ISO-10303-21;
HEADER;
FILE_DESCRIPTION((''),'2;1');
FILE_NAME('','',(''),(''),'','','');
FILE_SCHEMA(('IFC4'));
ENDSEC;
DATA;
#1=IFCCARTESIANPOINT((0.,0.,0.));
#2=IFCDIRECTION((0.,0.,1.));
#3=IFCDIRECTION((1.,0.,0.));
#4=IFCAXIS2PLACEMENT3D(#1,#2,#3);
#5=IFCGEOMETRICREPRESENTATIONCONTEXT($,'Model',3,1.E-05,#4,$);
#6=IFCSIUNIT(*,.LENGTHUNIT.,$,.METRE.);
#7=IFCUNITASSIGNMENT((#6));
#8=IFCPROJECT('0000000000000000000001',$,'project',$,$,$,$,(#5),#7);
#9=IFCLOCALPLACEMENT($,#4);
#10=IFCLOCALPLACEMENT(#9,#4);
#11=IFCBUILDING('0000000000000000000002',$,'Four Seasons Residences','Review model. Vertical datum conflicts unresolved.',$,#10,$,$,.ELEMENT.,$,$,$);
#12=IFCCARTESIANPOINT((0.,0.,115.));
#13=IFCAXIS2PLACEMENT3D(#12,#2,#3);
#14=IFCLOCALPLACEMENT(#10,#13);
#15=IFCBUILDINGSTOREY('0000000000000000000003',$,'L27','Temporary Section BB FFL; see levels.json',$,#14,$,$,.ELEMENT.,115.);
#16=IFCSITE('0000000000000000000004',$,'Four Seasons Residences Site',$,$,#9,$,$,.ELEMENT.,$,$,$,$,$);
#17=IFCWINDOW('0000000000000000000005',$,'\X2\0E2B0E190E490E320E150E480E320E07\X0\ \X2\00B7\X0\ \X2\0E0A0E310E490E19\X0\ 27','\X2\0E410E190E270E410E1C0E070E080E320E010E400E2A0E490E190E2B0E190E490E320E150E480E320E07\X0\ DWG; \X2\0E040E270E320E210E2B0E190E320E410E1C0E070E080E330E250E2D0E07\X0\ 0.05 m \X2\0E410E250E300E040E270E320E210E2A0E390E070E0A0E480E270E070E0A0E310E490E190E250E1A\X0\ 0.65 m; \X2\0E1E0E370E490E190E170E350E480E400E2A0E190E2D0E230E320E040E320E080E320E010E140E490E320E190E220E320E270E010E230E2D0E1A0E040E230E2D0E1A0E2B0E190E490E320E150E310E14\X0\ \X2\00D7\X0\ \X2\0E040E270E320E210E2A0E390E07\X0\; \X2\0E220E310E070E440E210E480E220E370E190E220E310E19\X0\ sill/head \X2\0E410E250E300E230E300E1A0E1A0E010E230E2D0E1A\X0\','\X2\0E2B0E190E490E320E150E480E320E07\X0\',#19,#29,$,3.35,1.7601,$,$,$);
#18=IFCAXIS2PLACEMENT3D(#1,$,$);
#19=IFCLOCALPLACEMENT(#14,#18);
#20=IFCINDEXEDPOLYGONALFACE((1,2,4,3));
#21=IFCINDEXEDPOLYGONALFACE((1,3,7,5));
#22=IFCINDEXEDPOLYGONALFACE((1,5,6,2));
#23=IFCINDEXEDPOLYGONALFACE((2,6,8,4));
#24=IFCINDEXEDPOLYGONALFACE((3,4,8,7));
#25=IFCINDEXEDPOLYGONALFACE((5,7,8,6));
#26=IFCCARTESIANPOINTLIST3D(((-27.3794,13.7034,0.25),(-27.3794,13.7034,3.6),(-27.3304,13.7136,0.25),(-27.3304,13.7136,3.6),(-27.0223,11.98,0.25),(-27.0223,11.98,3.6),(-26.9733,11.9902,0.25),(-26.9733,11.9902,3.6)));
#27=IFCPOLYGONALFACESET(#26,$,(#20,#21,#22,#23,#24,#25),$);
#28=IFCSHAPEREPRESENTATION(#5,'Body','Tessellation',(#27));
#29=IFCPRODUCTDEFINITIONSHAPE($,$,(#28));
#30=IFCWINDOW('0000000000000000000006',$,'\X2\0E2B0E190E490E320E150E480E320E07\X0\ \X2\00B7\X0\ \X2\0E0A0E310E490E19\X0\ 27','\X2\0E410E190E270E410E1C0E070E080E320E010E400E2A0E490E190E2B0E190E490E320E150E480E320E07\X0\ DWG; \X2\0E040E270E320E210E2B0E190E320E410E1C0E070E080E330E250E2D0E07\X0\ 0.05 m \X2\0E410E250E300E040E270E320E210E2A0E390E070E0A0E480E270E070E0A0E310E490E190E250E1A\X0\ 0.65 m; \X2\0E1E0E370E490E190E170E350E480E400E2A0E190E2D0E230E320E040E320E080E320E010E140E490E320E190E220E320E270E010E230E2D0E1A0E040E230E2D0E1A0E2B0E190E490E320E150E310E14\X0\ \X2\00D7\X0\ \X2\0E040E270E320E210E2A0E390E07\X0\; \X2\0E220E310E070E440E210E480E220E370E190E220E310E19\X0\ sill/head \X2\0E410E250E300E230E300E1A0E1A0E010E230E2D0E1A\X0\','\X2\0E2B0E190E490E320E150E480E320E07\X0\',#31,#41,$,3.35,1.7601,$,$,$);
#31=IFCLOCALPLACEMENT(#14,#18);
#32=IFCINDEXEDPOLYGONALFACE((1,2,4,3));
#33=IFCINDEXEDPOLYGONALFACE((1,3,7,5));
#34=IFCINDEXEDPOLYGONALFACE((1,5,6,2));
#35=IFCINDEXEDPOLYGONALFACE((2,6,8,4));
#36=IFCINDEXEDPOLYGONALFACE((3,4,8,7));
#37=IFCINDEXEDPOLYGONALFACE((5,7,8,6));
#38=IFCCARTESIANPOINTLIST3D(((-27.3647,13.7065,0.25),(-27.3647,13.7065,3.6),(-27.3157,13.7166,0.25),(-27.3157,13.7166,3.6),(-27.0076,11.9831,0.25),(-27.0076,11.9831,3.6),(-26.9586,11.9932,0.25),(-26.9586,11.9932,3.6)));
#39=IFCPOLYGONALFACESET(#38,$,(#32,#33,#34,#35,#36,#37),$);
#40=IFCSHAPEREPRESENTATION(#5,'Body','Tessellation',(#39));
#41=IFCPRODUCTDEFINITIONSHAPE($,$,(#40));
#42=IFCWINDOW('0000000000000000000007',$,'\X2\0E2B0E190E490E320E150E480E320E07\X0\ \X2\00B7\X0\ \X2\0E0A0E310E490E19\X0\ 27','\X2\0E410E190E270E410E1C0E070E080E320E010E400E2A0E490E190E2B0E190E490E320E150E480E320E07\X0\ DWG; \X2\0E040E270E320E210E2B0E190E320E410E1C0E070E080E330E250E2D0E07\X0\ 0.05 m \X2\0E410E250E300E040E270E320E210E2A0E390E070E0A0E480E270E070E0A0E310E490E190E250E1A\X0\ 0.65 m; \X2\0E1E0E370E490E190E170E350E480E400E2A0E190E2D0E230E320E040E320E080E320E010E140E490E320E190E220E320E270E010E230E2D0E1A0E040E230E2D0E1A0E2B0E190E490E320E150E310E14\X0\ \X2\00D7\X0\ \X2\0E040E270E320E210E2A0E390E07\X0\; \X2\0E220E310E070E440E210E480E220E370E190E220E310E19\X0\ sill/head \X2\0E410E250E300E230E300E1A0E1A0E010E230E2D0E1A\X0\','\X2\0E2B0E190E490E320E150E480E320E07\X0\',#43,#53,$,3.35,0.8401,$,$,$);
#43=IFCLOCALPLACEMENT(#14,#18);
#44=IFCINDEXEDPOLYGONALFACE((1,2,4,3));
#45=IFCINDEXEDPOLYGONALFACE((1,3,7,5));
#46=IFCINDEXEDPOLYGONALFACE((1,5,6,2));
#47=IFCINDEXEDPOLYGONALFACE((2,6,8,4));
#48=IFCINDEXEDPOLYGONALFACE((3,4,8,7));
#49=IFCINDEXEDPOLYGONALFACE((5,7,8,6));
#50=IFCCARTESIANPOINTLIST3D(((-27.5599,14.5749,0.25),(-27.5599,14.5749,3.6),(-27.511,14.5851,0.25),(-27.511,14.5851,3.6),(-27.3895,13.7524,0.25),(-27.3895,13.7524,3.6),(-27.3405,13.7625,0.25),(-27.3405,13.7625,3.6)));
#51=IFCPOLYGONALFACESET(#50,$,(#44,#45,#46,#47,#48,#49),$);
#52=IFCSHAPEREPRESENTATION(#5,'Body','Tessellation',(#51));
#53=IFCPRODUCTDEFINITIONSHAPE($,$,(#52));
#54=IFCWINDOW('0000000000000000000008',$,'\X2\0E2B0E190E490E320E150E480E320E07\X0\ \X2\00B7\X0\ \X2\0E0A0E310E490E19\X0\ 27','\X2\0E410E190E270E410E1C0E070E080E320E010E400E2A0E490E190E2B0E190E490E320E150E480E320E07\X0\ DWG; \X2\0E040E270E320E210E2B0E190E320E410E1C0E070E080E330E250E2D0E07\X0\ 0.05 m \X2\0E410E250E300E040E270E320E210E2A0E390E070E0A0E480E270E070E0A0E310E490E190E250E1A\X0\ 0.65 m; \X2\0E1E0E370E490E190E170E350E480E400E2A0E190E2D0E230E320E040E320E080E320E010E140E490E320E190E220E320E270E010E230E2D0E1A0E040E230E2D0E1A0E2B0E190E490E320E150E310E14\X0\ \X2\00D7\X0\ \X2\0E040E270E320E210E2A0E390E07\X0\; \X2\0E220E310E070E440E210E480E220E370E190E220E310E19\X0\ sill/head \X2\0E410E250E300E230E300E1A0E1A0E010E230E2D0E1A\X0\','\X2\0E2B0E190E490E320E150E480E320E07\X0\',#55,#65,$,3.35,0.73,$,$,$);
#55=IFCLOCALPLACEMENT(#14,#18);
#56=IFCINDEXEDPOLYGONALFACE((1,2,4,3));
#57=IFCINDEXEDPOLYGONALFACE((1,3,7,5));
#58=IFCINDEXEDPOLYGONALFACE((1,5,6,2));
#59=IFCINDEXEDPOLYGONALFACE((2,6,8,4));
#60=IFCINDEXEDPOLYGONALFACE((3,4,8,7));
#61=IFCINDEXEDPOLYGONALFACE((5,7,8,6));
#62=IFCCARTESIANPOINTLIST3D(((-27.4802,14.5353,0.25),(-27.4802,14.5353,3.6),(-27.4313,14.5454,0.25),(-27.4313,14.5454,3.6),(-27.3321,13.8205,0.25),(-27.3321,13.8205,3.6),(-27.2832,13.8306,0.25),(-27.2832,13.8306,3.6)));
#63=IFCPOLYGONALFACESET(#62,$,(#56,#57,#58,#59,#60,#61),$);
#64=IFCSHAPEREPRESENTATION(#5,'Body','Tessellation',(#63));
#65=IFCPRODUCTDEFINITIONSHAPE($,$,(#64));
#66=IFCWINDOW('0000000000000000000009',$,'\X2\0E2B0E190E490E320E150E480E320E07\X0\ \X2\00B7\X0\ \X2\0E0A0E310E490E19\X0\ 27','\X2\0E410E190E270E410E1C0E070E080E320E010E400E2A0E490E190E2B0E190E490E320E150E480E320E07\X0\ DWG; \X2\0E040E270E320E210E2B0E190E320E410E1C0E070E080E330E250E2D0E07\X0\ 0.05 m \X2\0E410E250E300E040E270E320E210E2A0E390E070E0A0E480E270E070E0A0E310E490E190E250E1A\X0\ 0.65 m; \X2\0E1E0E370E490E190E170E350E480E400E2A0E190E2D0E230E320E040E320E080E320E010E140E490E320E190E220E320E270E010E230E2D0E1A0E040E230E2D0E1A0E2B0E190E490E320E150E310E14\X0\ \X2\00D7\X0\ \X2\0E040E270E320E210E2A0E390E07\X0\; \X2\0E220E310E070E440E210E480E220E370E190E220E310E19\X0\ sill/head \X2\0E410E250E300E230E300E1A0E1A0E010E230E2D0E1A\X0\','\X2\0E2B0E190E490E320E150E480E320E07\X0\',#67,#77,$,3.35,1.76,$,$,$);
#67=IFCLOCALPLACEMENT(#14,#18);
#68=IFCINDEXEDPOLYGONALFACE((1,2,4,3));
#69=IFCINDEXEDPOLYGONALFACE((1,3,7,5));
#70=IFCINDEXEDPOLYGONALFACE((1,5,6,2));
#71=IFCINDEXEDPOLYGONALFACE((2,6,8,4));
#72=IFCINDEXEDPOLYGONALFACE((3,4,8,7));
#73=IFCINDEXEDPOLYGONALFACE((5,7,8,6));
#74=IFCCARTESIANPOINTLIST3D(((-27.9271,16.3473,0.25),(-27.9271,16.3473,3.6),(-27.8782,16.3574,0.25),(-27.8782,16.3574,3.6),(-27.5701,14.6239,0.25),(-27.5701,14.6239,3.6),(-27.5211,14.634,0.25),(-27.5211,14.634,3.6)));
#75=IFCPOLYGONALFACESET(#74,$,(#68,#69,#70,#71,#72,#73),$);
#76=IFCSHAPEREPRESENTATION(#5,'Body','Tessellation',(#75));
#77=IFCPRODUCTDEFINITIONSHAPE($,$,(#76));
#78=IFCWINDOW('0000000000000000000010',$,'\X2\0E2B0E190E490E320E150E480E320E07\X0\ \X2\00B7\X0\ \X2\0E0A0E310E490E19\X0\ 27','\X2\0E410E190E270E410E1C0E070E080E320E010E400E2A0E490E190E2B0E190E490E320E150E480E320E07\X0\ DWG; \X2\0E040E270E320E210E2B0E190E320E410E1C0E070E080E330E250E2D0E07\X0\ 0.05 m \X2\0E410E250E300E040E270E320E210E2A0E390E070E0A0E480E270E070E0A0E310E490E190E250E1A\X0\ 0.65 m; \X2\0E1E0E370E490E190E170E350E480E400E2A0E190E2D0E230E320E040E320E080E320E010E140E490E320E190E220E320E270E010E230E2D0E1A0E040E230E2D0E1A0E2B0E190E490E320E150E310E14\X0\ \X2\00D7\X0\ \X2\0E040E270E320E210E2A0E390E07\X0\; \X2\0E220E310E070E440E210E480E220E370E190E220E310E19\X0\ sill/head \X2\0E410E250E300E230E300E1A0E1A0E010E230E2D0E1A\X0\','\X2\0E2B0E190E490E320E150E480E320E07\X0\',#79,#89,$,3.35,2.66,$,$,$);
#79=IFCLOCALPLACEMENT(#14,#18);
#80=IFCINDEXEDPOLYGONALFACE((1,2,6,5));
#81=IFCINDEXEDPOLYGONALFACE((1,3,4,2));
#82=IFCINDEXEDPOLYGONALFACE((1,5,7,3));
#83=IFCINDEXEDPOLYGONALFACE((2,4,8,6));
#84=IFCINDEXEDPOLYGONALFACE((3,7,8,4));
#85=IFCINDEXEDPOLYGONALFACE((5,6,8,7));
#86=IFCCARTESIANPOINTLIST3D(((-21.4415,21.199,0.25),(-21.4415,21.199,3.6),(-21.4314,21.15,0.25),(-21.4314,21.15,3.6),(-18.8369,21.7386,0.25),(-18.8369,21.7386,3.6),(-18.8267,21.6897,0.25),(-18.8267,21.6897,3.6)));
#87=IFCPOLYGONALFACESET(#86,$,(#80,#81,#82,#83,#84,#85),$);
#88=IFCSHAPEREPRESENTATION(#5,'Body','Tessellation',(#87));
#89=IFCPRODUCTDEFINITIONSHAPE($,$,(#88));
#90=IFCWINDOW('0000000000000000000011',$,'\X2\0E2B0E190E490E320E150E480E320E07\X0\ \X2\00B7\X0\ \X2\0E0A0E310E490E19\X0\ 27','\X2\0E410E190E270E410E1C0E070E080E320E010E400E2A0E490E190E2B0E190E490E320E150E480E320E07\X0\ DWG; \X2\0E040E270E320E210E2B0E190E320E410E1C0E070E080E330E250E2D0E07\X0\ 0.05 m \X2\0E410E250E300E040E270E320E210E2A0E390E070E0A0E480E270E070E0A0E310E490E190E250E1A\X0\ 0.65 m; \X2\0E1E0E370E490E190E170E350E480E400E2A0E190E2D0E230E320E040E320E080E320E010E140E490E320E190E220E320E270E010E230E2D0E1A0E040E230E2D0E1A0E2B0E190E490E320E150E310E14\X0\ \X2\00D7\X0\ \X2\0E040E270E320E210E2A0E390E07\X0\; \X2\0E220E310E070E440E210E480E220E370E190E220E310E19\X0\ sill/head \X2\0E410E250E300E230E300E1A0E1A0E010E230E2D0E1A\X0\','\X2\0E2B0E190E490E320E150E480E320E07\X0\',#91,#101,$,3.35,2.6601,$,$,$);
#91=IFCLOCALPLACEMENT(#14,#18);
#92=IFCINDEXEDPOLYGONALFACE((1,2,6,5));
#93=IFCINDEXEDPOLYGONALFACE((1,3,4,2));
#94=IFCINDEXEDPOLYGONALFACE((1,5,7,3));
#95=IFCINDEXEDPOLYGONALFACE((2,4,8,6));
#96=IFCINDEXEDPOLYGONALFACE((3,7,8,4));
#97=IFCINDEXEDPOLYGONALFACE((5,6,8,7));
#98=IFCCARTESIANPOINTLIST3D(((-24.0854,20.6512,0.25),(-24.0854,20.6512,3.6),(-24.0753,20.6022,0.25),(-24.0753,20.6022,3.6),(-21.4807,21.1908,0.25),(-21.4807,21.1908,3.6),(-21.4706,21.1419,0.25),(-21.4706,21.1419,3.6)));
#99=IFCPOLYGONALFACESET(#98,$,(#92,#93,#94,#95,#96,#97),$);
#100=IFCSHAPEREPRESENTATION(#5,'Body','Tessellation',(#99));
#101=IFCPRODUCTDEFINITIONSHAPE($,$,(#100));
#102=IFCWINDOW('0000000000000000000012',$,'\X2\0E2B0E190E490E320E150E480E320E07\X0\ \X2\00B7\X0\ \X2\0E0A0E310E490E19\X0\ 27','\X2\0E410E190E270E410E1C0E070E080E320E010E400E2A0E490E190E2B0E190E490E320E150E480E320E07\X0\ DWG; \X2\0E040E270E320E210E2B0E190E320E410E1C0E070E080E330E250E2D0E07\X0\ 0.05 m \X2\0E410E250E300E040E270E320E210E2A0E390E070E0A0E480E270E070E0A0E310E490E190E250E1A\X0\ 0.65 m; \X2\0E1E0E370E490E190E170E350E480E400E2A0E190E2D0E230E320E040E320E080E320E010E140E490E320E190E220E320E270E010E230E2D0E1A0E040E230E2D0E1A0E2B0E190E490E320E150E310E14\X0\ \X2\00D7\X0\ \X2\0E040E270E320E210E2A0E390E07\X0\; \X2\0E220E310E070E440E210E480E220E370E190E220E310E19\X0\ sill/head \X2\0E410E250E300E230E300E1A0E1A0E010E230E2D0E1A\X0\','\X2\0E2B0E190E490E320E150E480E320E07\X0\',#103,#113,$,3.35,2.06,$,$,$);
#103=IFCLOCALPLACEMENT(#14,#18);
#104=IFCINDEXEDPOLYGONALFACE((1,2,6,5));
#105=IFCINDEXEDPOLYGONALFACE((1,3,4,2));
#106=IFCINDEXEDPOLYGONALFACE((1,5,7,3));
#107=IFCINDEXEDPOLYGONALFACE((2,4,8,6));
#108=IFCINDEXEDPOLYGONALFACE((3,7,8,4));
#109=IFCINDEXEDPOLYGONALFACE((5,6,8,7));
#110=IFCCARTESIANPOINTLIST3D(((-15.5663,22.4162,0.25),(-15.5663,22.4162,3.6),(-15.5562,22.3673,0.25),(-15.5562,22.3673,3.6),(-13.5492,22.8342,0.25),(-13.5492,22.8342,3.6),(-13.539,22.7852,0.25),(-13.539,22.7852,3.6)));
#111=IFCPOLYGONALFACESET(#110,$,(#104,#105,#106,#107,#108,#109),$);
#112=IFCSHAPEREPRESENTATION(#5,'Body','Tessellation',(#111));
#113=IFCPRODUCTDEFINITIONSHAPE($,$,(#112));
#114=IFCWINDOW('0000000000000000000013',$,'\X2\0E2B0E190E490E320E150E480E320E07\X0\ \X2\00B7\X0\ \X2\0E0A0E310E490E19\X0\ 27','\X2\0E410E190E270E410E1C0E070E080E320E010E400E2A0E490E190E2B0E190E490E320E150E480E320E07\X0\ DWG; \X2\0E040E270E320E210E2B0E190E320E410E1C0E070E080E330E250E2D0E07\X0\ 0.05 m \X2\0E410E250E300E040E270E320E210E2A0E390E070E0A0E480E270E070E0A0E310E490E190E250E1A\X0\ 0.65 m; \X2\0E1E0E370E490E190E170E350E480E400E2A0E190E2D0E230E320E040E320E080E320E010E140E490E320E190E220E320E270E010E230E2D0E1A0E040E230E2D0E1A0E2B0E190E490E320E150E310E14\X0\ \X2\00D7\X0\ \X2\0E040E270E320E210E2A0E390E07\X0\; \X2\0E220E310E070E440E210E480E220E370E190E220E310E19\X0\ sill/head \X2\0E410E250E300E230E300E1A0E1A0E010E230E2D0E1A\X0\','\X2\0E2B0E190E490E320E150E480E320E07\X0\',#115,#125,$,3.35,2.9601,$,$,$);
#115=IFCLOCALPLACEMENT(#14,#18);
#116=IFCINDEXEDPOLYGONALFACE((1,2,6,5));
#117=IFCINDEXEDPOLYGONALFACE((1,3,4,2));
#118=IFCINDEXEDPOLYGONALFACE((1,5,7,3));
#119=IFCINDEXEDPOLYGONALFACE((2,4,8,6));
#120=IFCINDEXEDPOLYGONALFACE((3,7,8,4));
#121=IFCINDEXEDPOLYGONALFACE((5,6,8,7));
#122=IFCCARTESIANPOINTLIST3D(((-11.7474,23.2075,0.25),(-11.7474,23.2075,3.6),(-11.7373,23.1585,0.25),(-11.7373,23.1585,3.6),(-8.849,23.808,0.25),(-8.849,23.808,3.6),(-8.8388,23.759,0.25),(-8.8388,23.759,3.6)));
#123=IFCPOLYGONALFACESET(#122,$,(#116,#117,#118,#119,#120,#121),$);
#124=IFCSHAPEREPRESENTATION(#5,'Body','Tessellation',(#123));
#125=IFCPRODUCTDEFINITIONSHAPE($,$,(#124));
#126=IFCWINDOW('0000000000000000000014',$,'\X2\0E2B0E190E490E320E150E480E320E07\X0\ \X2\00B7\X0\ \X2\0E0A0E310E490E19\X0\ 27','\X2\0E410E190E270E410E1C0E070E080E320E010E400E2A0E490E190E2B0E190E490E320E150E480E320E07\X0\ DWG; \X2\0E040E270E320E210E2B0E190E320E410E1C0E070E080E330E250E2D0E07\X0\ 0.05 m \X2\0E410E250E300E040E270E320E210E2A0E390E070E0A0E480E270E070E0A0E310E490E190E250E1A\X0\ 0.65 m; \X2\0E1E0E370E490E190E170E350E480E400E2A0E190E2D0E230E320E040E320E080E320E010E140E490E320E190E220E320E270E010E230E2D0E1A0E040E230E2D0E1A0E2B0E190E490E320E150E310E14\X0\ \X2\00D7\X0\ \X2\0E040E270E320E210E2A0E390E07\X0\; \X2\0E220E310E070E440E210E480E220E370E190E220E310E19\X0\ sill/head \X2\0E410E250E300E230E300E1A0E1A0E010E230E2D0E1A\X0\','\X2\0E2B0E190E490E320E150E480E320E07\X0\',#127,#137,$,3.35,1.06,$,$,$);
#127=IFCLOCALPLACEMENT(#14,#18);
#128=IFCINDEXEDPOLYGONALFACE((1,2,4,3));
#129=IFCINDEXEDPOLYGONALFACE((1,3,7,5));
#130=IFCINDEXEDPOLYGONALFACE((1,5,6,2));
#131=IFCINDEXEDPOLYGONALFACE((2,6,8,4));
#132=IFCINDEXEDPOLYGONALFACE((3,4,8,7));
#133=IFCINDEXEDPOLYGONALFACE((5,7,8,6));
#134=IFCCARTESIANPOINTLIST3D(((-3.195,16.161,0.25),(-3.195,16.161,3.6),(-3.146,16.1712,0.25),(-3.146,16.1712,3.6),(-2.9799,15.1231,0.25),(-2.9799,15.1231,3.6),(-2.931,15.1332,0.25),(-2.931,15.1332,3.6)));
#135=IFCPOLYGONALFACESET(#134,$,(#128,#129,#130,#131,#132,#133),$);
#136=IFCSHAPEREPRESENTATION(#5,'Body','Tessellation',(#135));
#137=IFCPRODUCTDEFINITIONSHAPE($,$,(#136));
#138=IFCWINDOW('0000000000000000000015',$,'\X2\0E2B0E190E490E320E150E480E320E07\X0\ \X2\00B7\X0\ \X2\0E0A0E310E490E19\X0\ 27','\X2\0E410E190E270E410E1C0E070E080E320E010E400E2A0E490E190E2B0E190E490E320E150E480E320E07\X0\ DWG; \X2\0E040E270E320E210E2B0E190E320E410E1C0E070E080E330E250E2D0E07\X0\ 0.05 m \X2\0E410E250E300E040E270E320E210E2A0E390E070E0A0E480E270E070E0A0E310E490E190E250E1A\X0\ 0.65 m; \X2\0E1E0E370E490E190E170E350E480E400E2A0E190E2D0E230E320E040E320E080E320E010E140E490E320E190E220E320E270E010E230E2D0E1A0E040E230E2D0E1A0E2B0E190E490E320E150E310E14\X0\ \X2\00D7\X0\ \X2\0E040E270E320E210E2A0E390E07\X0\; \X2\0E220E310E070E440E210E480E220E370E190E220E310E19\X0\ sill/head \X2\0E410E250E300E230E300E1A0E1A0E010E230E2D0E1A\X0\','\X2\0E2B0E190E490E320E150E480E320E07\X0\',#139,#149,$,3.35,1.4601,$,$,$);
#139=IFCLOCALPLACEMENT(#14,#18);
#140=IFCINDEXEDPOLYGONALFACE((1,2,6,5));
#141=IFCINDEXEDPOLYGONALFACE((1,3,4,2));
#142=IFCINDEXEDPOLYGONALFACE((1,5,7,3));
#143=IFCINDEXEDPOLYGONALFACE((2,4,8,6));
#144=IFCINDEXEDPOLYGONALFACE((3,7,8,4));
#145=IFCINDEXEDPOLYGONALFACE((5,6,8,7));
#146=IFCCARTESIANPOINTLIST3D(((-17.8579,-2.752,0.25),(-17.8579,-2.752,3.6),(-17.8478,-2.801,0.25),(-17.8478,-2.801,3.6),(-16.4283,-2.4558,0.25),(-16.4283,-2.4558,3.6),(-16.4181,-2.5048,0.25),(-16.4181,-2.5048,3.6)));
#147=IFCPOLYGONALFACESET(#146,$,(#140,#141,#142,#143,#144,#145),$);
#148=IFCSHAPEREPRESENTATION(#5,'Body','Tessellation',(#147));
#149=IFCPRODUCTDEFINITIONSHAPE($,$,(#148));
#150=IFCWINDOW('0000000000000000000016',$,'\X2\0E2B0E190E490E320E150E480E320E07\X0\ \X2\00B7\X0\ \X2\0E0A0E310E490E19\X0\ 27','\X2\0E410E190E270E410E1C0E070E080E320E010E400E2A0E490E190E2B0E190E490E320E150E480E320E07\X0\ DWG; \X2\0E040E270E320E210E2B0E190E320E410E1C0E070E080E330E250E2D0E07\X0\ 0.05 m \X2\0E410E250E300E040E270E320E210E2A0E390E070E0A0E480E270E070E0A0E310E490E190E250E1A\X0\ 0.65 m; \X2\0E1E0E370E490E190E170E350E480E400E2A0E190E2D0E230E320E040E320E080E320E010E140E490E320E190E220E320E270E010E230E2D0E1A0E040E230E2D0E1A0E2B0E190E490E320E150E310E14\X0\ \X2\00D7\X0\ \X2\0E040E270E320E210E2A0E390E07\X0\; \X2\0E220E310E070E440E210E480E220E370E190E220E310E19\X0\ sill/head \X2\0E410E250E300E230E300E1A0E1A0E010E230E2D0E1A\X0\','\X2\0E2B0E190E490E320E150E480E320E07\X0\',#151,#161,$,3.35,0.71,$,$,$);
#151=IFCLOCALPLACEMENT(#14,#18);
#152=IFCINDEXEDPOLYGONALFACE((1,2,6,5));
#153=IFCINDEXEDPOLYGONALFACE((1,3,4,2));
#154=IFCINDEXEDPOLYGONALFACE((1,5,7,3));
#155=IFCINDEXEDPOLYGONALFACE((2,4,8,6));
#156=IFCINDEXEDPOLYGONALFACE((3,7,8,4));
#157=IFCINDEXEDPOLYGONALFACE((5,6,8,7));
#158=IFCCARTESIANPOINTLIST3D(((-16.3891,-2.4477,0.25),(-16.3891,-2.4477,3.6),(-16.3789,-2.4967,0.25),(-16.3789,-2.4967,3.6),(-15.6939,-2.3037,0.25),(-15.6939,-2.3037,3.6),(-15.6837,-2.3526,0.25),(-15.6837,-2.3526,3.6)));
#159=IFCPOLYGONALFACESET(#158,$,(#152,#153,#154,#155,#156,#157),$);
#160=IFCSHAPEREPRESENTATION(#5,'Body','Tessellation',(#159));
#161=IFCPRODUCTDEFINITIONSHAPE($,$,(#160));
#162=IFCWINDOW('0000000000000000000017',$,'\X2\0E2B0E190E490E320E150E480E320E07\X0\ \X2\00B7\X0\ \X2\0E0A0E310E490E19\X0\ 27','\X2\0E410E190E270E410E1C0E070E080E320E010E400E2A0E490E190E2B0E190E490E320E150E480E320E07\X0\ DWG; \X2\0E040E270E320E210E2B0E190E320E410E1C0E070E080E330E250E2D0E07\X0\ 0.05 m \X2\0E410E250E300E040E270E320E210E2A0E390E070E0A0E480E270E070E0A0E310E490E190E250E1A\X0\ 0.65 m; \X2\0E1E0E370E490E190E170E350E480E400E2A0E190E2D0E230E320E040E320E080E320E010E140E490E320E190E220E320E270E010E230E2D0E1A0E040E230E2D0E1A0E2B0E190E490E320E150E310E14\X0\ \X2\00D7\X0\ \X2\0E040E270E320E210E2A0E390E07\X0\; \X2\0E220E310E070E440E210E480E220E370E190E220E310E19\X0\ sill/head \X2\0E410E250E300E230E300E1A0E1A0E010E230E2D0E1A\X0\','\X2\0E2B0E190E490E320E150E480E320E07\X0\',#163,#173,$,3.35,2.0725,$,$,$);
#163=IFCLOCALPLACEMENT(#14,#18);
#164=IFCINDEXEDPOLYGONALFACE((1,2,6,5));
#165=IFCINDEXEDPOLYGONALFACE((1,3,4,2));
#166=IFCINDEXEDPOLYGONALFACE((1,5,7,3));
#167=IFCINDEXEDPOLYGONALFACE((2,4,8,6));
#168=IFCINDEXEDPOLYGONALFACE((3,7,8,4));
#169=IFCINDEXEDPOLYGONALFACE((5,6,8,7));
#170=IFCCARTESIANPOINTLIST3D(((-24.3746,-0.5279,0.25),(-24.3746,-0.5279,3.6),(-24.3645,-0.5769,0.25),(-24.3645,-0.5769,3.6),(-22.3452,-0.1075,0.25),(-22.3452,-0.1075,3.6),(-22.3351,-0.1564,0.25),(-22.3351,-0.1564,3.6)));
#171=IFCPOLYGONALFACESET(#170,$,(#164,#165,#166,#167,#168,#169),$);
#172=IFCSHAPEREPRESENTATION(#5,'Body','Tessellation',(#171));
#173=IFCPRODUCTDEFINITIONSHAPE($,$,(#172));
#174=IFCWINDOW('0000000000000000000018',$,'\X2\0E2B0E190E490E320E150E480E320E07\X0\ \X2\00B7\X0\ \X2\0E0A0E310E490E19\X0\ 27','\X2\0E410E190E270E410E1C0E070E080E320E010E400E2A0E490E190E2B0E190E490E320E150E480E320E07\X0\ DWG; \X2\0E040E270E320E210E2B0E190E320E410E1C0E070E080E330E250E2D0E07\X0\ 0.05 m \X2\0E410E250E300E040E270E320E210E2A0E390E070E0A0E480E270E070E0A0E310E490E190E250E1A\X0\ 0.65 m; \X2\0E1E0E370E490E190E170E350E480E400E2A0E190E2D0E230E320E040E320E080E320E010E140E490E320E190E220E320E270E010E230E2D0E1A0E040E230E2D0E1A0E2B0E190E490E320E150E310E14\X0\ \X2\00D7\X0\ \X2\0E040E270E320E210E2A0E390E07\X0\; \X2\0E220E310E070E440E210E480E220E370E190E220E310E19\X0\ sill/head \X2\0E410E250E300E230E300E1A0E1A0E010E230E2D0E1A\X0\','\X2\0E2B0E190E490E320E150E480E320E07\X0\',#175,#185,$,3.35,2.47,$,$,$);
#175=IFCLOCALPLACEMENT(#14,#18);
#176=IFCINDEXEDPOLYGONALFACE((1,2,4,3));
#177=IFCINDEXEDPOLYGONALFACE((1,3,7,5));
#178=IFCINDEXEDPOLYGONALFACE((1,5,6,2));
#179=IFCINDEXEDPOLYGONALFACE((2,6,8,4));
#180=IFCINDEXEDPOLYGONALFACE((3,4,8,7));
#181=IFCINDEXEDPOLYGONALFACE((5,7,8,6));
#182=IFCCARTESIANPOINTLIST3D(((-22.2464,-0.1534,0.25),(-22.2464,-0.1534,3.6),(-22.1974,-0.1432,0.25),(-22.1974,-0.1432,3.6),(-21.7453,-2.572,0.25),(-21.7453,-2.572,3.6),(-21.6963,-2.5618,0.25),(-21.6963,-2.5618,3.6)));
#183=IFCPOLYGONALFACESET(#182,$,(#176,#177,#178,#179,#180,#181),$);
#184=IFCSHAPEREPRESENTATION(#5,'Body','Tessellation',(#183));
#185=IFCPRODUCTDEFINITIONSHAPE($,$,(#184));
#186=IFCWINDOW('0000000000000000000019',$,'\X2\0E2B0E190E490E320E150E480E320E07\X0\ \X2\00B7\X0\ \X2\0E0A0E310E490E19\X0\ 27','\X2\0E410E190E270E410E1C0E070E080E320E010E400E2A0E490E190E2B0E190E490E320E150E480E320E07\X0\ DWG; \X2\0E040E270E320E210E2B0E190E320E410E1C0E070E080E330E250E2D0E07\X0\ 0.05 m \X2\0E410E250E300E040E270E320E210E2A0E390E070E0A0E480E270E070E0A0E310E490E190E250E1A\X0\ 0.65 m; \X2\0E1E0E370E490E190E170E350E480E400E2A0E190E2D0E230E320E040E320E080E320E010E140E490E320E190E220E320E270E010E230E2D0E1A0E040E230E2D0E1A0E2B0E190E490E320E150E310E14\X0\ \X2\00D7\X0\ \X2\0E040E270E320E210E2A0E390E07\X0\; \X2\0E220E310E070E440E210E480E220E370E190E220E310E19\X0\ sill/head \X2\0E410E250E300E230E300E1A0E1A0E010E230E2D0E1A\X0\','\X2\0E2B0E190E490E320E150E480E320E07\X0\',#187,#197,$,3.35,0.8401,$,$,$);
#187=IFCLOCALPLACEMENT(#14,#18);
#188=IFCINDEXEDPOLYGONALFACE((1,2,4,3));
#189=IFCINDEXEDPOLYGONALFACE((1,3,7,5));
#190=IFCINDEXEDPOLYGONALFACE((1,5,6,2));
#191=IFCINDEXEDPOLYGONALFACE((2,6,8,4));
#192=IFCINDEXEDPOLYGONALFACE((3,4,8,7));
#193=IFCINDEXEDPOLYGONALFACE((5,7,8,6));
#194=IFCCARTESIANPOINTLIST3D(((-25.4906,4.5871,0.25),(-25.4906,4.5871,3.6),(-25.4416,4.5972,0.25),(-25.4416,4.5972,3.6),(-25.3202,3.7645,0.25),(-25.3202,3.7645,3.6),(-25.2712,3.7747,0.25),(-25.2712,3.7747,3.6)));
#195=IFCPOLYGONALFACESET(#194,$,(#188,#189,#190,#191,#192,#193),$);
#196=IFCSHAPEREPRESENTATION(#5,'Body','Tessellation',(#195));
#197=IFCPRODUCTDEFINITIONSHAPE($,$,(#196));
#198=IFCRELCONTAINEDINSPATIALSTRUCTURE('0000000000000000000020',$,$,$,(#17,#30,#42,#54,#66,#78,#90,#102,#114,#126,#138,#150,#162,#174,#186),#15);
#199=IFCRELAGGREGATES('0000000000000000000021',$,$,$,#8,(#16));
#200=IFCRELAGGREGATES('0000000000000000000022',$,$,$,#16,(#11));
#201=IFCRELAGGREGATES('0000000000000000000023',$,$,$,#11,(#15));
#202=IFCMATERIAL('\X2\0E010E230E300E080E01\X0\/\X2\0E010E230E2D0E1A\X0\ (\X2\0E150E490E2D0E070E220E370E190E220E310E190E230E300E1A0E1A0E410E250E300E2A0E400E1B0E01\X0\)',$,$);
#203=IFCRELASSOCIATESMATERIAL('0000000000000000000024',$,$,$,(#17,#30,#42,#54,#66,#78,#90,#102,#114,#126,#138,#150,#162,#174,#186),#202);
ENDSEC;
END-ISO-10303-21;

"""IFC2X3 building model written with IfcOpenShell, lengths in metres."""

from ifc_helpers import new_model, si_unit, frame, origin_with_axes, place, context, project, spatial, polyline, outline, extrude, material, element, save


model = new_model("IFC2X3")

# Units and contexts
model_context = context("Model", 3, precision=1e-05, world=origin_with_axes())
ifc_project = project(units=[si_unit("LENGTHUNIT", "METRE")], contexts=[model_context])

# Site, building, storey
site_placement = place(None, origin_with_axes())
site = spatial("IfcSite", under=ifc_project, at=site_placement, Name="Four Seasons Residences Site", CompositionType="ELEMENT")
building_placement = place(site_placement, origin_with_axes())
building = spatial("IfcBuilding", under=site, at=building_placement, Name="Four Seasons Residences", Description="Review model. Vertical datum conflicts unresolved.", CompositionType="ELEMENT")
storey_placement = place(building_placement, frame((0.0, 0.0, 115.0), z_axis=(0.0, 0.0, 1.0), x_axis=(1.0, 0.0, 0.0)))
storey = spatial("IfcBuildingStorey", under=building, at=storey_placement, Name="L27", Description="Temporary Section BB FFL; see levels.json", CompositionType="ELEMENT", Elevation=115.0)

# Windows
ifc_material = material(Name="กระจก/กรอบ (ต้องยืนยันระบบและสเปก)")
window_1_placement = place(storey_placement, origin_with_axes())
element("IfcWindow", 1, at=window_1_placement, inside=storey, material=ifc_material, Name="หน้าต่าง · ชั้น 27", Description="แนวแผงจากเส้นหน้าต่าง DWG; ความหนาแผงจำลอง 0.05 m และความสูงช่วงชั้นลบ 0.65 m; พื้นที่เสนอราคาจากด้านยาวกรอบครอบหน้าตัด × ความสูง; ยังไม่ยืนยัน sill/head และระบบกรอบ", ObjectType="หน้าต่าง", OverallHeight=3.35, OverallWidth=1.7601, context=model_context, shape_type="SweptSolid", body=[
    extrude(outline(polyline([(-26.9733, 11.9902), (-27.0223, 11.98), (-27.3794, 13.7034), (-27.3304, 13.7136), (-26.9733, 11.9902)])), frame((0.0, 0.0, 0.25), z_axis=(0.0, 0.0, 1.0), x_axis=(1.0, 0.0, 0.0)), (0.0, 0.0, 1.0), 3.35),
])
window_2_placement = place(storey_placement, origin_with_axes())
element("IfcWindow", 2, at=window_2_placement, inside=storey, material=ifc_material, Name="หน้าต่าง · ชั้น 27", Description="แนวแผงจากเส้นหน้าต่าง DWG; ความหนาแผงจำลอง 0.05 m และความสูงช่วงชั้นลบ 0.65 m; พื้นที่เสนอราคาจากด้านยาวกรอบครอบหน้าตัด × ความสูง; ยังไม่ยืนยัน sill/head และระบบกรอบ", ObjectType="หน้าต่าง", OverallHeight=3.35, OverallWidth=1.7601, context=model_context, shape_type="SweptSolid", body=[
    extrude(outline(polyline([(-26.9586, 11.9932), (-27.0076, 11.9831), (-27.3647, 13.7065), (-27.3157, 13.7166), (-26.9586, 11.9932)])), frame((0.0, 0.0, 0.25), z_axis=(0.0, 0.0, 1.0), x_axis=(1.0, 0.0, 0.0)), (0.0, 0.0, 1.0), 3.35),
])
window_3_placement = place(storey_placement, origin_with_axes())
element("IfcWindow", 3, at=window_3_placement, inside=storey, material=ifc_material, Name="หน้าต่าง · ชั้น 27", Description="แนวแผงจากเส้นหน้าต่าง DWG; ความหนาแผงจำลอง 0.05 m และความสูงช่วงชั้นลบ 0.65 m; พื้นที่เสนอราคาจากด้านยาวกรอบครอบหน้าตัด × ความสูง; ยังไม่ยืนยัน sill/head และระบบกรอบ", ObjectType="หน้าต่าง", OverallHeight=3.35, OverallWidth=0.8401, context=model_context, shape_type="SweptSolid", body=[
    extrude(outline(polyline([(-27.3405, 13.7625), (-27.3895, 13.7524), (-27.5599, 14.5749), (-27.511, 14.5851), (-27.3405, 13.7625)])), frame((0.0, 0.0, 0.25), z_axis=(0.0, 0.0, 1.0), x_axis=(1.0, 0.0, 0.0)), (0.0, 0.0, 1.0), 3.35),
])
window_4_placement = place(storey_placement, origin_with_axes())
element("IfcWindow", 4, at=window_4_placement, inside=storey, material=ifc_material, Name="หน้าต่าง · ชั้น 27", Description="แนวแผงจากเส้นหน้าต่าง DWG; ความหนาแผงจำลอง 0.05 m และความสูงช่วงชั้นลบ 0.65 m; พื้นที่เสนอราคาจากด้านยาวกรอบครอบหน้าตัด × ความสูง; ยังไม่ยืนยัน sill/head และระบบกรอบ", ObjectType="หน้าต่าง", OverallHeight=3.35, OverallWidth=0.73, context=model_context, shape_type="SweptSolid", body=[
    extrude(outline(polyline([(-27.2832, 13.8306), (-27.3321, 13.8205), (-27.4802, 14.5353), (-27.4313, 14.5454), (-27.2832, 13.8306)])), frame((0.0, 0.0, 0.25), z_axis=(0.0, 0.0, 1.0), x_axis=(1.0, 0.0, 0.0)), (0.0, 0.0, 1.0), 3.35),
])
window_5_placement = place(storey_placement, origin_with_axes())
element("IfcWindow", 5, at=window_5_placement, inside=storey, material=ifc_material, Name="หน้าต่าง · ชั้น 27", Description="แนวแผงจากเส้นหน้าต่าง DWG; ความหนาแผงจำลอง 0.05 m และความสูงช่วงชั้นลบ 0.65 m; พื้นที่เสนอราคาจากด้านยาวกรอบครอบหน้าตัด × ความสูง; ยังไม่ยืนยัน sill/head และระบบกรอบ", ObjectType="หน้าต่าง", OverallHeight=3.35, OverallWidth=1.76, context=model_context, shape_type="SweptSolid", body=[
    extrude(outline(polyline([(-27.5211, 14.634), (-27.5701, 14.6239), (-27.9271, 16.3473), (-27.8782, 16.3574), (-27.5211, 14.634)])), frame((0.0, 0.0, 0.25), z_axis=(0.0, 0.0, 1.0), x_axis=(1.0, 0.0, 0.0)), (0.0, 0.0, 1.0), 3.35),
])
window_6_placement = place(storey_placement, origin_with_axes())
element("IfcWindow", 6, at=window_6_placement, inside=storey, material=ifc_material, Name="หน้าต่าง · ชั้น 27", Description="แนวแผงจากเส้นหน้าต่าง DWG; ความหนาแผงจำลอง 0.05 m และความสูงช่วงชั้นลบ 0.65 m; พื้นที่เสนอราคาจากด้านยาวกรอบครอบหน้าตัด × ความสูง; ยังไม่ยืนยัน sill/head และระบบกรอบ", ObjectType="หน้าต่าง", OverallHeight=3.35, OverallWidth=2.66, context=model_context, shape_type="SweptSolid", body=[
    extrude(outline(polyline([(-18.8369, 21.7386), (-18.8267, 21.6897), (-21.4314, 21.15), (-21.4415, 21.199), (-18.8369, 21.7386)])), frame((0.0, 0.0, 0.25), z_axis=(0.0, 0.0, 1.0), x_axis=(1.0, 0.0, 0.0)), (0.0, 0.0, 1.0), 3.35),
])
window_7_placement = place(storey_placement, origin_with_axes())
element("IfcWindow", 7, at=window_7_placement, inside=storey, material=ifc_material, Name="หน้าต่าง · ชั้น 27", Description="แนวแผงจากเส้นหน้าต่าง DWG; ความหนาแผงจำลอง 0.05 m และความสูงช่วงชั้นลบ 0.65 m; พื้นที่เสนอราคาจากด้านยาวกรอบครอบหน้าตัด × ความสูง; ยังไม่ยืนยัน sill/head และระบบกรอบ", ObjectType="หน้าต่าง", OverallHeight=3.35, OverallWidth=2.6601, context=model_context, shape_type="SweptSolid", body=[
    extrude(outline(polyline([(-21.4807, 21.1908), (-21.4706, 21.1419), (-24.0753, 20.6022), (-24.0854, 20.6512), (-21.4807, 21.1908)])), frame((0.0, 0.0, 0.25), z_axis=(0.0, 0.0, 1.0), x_axis=(1.0, 0.0, 0.0)), (0.0, 0.0, 1.0), 3.35),
])
window_8_placement = place(storey_placement, origin_with_axes())
element("IfcWindow", 8, at=window_8_placement, inside=storey, material=ifc_material, Name="หน้าต่าง · ชั้น 27", Description="แนวแผงจากเส้นหน้าต่าง DWG; ความหนาแผงจำลอง 0.05 m และความสูงช่วงชั้นลบ 0.65 m; พื้นที่เสนอราคาจากด้านยาวกรอบครอบหน้าตัด × ความสูง; ยังไม่ยืนยัน sill/head และระบบกรอบ", ObjectType="หน้าต่าง", OverallHeight=3.35, OverallWidth=2.06, context=model_context, shape_type="SweptSolid", body=[
    extrude(outline(polyline([(-13.5492, 22.8342), (-13.539, 22.7852), (-15.5562, 22.3673), (-15.5663, 22.4162), (-13.5492, 22.8342)])), frame((0.0, 0.0, 0.25), z_axis=(0.0, 0.0, 1.0), x_axis=(1.0, 0.0, 0.0)), (0.0, 0.0, 1.0), 3.35),
])
window_9_placement = place(storey_placement, origin_with_axes())
element("IfcWindow", 9, at=window_9_placement, inside=storey, material=ifc_material, Name="หน้าต่าง · ชั้น 27", Description="แนวแผงจากเส้นหน้าต่าง DWG; ความหนาแผงจำลอง 0.05 m และความสูงช่วงชั้นลบ 0.65 m; พื้นที่เสนอราคาจากด้านยาวกรอบครอบหน้าตัด × ความสูง; ยังไม่ยืนยัน sill/head และระบบกรอบ", ObjectType="หน้าต่าง", OverallHeight=3.35, OverallWidth=2.9601, context=model_context, shape_type="SweptSolid", body=[
    extrude(outline(polyline([(-8.849, 23.808), (-8.8388, 23.759), (-11.7373, 23.1585), (-11.7474, 23.2075), (-8.849, 23.808)])), frame((0.0, 0.0, 0.25), z_axis=(0.0, 0.0, 1.0), x_axis=(1.0, 0.0, 0.0)), (0.0, 0.0, 1.0), 3.35),
])
window_10_placement = place(storey_placement, origin_with_axes())
element("IfcWindow", 10, at=window_10_placement, inside=storey, material=ifc_material, Name="หน้าต่าง · ชั้น 27", Description="แนวแผงจากเส้นหน้าต่าง DWG; ความหนาแผงจำลอง 0.05 m และความสูงช่วงชั้นลบ 0.65 m; พื้นที่เสนอราคาจากด้านยาวกรอบครอบหน้าตัด × ความสูง; ยังไม่ยืนยัน sill/head และระบบกรอบ", ObjectType="หน้าต่าง", OverallHeight=3.35, OverallWidth=1.06, context=model_context, shape_type="SweptSolid", body=[
    extrude(outline(polyline([(-3.195, 16.161), (-3.146, 16.1712), (-2.931, 15.1332), (-2.9799, 15.1231), (-3.195, 16.161)])), frame((0.0, 0.0, 0.25), z_axis=(0.0, 0.0, 1.0), x_axis=(1.0, 0.0, 0.0)), (0.0, 0.0, 1.0), 3.35),
])
window_11_placement = place(storey_placement, origin_with_axes())
element("IfcWindow", 11, at=window_11_placement, inside=storey, material=ifc_material, Name="หน้าต่าง · ชั้น 27", Description="แนวแผงจากเส้นหน้าต่าง DWG; ความหนาแผงจำลอง 0.05 m และความสูงช่วงชั้นลบ 0.65 m; พื้นที่เสนอราคาจากด้านยาวกรอบครอบหน้าตัด × ความสูง; ยังไม่ยืนยัน sill/head และระบบกรอบ", ObjectType="หน้าต่าง", OverallHeight=3.35, OverallWidth=1.4601, context=model_context, shape_type="SweptSolid", body=[
    extrude(outline(polyline([(-16.4283, -2.4558), (-16.4181, -2.5048), (-17.8478, -2.801), (-17.8579, -2.752), (-16.4283, -2.4558)])), frame((0.0, 0.0, 0.25), z_axis=(0.0, 0.0, 1.0), x_axis=(1.0, 0.0, 0.0)), (0.0, 0.0, 1.0), 3.35),
])
window_12_placement = place(storey_placement, origin_with_axes())
element("IfcWindow", 12, at=window_12_placement, inside=storey, material=ifc_material, Name="หน้าต่าง · ชั้น 27", Description="แนวแผงจากเส้นหน้าต่าง DWG; ความหนาแผงจำลอง 0.05 m และความสูงช่วงชั้นลบ 0.65 m; พื้นที่เสนอราคาจากด้านยาวกรอบครอบหน้าตัด × ความสูง; ยังไม่ยืนยัน sill/head และระบบกรอบ", ObjectType="หน้าต่าง", OverallHeight=3.35, OverallWidth=0.71, context=model_context, shape_type="SweptSolid", body=[
    extrude(outline(polyline([(-15.6939, -2.3037), (-15.6837, -2.3526), (-16.3789, -2.4967), (-16.3891, -2.4477), (-15.6939, -2.3037)])), frame((0.0, 0.0, 0.25), z_axis=(0.0, 0.0, 1.0), x_axis=(1.0, 0.0, 0.0)), (0.0, 0.0, 1.0), 3.35),
])
window_13_placement = place(storey_placement, origin_with_axes())
element("IfcWindow", 13, at=window_13_placement, inside=storey, material=ifc_material, Name="หน้าต่าง · ชั้น 27", Description="แนวแผงจากเส้นหน้าต่าง DWG; ความหนาแผงจำลอง 0.05 m และความสูงช่วงชั้นลบ 0.65 m; พื้นที่เสนอราคาจากด้านยาวกรอบครอบหน้าตัด × ความสูง; ยังไม่ยืนยัน sill/head และระบบกรอบ", ObjectType="หน้าต่าง", OverallHeight=3.35, OverallWidth=2.0725, context=model_context, shape_type="SweptSolid", body=[
    extrude(outline(polyline([(-22.3452, -0.1075), (-22.3351, -0.1564), (-24.3645, -0.5769), (-24.3746, -0.5279), (-22.3452, -0.1075)])), frame((0.0, 0.0, 0.25), z_axis=(0.0, 0.0, 1.0), x_axis=(1.0, 0.0, 0.0)), (0.0, 0.0, 1.0), 3.35),
])
window_14_placement = place(storey_placement, origin_with_axes())
element("IfcWindow", 14, at=window_14_placement, inside=storey, material=ifc_material, Name="หน้าต่าง · ชั้น 27", Description="แนวแผงจากเส้นหน้าต่าง DWG; ความหนาแผงจำลอง 0.05 m และความสูงช่วงชั้นลบ 0.65 m; พื้นที่เสนอราคาจากด้านยาวกรอบครอบหน้าตัด × ความสูง; ยังไม่ยืนยัน sill/head และระบบกรอบ", ObjectType="หน้าต่าง", OverallHeight=3.35, OverallWidth=2.47, context=model_context, shape_type="SweptSolid", body=[
    extrude(outline(polyline([(-22.2464, -0.1534), (-22.1974, -0.1432), (-21.6963, -2.5618), (-21.7453, -2.572), (-22.2464, -0.1534)])), frame((0.0, 0.0, 0.25), z_axis=(0.0, 0.0, 1.0), x_axis=(1.0, 0.0, 0.0)), (0.0, 0.0, 1.0), 3.35),
])
window_15_placement = place(storey_placement, origin_with_axes())
element("IfcWindow", 15, at=window_15_placement, inside=storey, material=ifc_material, Name="หน้าต่าง · ชั้น 27", Description="แนวแผงจากเส้นหน้าต่าง DWG; ความหนาแผงจำลอง 0.05 m และความสูงช่วงชั้นลบ 0.65 m; พื้นที่เสนอราคาจากด้านยาวกรอบครอบหน้าตัด × ความสูง; ยังไม่ยืนยัน sill/head และระบบกรอบ", ObjectType="หน้าต่าง", OverallHeight=3.35, OverallWidth=0.8401, context=model_context, shape_type="SweptSolid", body=[
    extrude(outline(polyline([(-25.2712, 3.7747), (-25.3202, 3.7645), (-25.4906, 4.5871), (-25.4416, 4.5972), (-25.2712, 3.7747)])), frame((0.0, 0.0, 0.25), z_axis=(0.0, 0.0, 1.0), x_axis=(1.0, 0.0, 0.0)), (0.0, 0.0, 1.0), 3.35),
])

save(model, "model.ifc")
